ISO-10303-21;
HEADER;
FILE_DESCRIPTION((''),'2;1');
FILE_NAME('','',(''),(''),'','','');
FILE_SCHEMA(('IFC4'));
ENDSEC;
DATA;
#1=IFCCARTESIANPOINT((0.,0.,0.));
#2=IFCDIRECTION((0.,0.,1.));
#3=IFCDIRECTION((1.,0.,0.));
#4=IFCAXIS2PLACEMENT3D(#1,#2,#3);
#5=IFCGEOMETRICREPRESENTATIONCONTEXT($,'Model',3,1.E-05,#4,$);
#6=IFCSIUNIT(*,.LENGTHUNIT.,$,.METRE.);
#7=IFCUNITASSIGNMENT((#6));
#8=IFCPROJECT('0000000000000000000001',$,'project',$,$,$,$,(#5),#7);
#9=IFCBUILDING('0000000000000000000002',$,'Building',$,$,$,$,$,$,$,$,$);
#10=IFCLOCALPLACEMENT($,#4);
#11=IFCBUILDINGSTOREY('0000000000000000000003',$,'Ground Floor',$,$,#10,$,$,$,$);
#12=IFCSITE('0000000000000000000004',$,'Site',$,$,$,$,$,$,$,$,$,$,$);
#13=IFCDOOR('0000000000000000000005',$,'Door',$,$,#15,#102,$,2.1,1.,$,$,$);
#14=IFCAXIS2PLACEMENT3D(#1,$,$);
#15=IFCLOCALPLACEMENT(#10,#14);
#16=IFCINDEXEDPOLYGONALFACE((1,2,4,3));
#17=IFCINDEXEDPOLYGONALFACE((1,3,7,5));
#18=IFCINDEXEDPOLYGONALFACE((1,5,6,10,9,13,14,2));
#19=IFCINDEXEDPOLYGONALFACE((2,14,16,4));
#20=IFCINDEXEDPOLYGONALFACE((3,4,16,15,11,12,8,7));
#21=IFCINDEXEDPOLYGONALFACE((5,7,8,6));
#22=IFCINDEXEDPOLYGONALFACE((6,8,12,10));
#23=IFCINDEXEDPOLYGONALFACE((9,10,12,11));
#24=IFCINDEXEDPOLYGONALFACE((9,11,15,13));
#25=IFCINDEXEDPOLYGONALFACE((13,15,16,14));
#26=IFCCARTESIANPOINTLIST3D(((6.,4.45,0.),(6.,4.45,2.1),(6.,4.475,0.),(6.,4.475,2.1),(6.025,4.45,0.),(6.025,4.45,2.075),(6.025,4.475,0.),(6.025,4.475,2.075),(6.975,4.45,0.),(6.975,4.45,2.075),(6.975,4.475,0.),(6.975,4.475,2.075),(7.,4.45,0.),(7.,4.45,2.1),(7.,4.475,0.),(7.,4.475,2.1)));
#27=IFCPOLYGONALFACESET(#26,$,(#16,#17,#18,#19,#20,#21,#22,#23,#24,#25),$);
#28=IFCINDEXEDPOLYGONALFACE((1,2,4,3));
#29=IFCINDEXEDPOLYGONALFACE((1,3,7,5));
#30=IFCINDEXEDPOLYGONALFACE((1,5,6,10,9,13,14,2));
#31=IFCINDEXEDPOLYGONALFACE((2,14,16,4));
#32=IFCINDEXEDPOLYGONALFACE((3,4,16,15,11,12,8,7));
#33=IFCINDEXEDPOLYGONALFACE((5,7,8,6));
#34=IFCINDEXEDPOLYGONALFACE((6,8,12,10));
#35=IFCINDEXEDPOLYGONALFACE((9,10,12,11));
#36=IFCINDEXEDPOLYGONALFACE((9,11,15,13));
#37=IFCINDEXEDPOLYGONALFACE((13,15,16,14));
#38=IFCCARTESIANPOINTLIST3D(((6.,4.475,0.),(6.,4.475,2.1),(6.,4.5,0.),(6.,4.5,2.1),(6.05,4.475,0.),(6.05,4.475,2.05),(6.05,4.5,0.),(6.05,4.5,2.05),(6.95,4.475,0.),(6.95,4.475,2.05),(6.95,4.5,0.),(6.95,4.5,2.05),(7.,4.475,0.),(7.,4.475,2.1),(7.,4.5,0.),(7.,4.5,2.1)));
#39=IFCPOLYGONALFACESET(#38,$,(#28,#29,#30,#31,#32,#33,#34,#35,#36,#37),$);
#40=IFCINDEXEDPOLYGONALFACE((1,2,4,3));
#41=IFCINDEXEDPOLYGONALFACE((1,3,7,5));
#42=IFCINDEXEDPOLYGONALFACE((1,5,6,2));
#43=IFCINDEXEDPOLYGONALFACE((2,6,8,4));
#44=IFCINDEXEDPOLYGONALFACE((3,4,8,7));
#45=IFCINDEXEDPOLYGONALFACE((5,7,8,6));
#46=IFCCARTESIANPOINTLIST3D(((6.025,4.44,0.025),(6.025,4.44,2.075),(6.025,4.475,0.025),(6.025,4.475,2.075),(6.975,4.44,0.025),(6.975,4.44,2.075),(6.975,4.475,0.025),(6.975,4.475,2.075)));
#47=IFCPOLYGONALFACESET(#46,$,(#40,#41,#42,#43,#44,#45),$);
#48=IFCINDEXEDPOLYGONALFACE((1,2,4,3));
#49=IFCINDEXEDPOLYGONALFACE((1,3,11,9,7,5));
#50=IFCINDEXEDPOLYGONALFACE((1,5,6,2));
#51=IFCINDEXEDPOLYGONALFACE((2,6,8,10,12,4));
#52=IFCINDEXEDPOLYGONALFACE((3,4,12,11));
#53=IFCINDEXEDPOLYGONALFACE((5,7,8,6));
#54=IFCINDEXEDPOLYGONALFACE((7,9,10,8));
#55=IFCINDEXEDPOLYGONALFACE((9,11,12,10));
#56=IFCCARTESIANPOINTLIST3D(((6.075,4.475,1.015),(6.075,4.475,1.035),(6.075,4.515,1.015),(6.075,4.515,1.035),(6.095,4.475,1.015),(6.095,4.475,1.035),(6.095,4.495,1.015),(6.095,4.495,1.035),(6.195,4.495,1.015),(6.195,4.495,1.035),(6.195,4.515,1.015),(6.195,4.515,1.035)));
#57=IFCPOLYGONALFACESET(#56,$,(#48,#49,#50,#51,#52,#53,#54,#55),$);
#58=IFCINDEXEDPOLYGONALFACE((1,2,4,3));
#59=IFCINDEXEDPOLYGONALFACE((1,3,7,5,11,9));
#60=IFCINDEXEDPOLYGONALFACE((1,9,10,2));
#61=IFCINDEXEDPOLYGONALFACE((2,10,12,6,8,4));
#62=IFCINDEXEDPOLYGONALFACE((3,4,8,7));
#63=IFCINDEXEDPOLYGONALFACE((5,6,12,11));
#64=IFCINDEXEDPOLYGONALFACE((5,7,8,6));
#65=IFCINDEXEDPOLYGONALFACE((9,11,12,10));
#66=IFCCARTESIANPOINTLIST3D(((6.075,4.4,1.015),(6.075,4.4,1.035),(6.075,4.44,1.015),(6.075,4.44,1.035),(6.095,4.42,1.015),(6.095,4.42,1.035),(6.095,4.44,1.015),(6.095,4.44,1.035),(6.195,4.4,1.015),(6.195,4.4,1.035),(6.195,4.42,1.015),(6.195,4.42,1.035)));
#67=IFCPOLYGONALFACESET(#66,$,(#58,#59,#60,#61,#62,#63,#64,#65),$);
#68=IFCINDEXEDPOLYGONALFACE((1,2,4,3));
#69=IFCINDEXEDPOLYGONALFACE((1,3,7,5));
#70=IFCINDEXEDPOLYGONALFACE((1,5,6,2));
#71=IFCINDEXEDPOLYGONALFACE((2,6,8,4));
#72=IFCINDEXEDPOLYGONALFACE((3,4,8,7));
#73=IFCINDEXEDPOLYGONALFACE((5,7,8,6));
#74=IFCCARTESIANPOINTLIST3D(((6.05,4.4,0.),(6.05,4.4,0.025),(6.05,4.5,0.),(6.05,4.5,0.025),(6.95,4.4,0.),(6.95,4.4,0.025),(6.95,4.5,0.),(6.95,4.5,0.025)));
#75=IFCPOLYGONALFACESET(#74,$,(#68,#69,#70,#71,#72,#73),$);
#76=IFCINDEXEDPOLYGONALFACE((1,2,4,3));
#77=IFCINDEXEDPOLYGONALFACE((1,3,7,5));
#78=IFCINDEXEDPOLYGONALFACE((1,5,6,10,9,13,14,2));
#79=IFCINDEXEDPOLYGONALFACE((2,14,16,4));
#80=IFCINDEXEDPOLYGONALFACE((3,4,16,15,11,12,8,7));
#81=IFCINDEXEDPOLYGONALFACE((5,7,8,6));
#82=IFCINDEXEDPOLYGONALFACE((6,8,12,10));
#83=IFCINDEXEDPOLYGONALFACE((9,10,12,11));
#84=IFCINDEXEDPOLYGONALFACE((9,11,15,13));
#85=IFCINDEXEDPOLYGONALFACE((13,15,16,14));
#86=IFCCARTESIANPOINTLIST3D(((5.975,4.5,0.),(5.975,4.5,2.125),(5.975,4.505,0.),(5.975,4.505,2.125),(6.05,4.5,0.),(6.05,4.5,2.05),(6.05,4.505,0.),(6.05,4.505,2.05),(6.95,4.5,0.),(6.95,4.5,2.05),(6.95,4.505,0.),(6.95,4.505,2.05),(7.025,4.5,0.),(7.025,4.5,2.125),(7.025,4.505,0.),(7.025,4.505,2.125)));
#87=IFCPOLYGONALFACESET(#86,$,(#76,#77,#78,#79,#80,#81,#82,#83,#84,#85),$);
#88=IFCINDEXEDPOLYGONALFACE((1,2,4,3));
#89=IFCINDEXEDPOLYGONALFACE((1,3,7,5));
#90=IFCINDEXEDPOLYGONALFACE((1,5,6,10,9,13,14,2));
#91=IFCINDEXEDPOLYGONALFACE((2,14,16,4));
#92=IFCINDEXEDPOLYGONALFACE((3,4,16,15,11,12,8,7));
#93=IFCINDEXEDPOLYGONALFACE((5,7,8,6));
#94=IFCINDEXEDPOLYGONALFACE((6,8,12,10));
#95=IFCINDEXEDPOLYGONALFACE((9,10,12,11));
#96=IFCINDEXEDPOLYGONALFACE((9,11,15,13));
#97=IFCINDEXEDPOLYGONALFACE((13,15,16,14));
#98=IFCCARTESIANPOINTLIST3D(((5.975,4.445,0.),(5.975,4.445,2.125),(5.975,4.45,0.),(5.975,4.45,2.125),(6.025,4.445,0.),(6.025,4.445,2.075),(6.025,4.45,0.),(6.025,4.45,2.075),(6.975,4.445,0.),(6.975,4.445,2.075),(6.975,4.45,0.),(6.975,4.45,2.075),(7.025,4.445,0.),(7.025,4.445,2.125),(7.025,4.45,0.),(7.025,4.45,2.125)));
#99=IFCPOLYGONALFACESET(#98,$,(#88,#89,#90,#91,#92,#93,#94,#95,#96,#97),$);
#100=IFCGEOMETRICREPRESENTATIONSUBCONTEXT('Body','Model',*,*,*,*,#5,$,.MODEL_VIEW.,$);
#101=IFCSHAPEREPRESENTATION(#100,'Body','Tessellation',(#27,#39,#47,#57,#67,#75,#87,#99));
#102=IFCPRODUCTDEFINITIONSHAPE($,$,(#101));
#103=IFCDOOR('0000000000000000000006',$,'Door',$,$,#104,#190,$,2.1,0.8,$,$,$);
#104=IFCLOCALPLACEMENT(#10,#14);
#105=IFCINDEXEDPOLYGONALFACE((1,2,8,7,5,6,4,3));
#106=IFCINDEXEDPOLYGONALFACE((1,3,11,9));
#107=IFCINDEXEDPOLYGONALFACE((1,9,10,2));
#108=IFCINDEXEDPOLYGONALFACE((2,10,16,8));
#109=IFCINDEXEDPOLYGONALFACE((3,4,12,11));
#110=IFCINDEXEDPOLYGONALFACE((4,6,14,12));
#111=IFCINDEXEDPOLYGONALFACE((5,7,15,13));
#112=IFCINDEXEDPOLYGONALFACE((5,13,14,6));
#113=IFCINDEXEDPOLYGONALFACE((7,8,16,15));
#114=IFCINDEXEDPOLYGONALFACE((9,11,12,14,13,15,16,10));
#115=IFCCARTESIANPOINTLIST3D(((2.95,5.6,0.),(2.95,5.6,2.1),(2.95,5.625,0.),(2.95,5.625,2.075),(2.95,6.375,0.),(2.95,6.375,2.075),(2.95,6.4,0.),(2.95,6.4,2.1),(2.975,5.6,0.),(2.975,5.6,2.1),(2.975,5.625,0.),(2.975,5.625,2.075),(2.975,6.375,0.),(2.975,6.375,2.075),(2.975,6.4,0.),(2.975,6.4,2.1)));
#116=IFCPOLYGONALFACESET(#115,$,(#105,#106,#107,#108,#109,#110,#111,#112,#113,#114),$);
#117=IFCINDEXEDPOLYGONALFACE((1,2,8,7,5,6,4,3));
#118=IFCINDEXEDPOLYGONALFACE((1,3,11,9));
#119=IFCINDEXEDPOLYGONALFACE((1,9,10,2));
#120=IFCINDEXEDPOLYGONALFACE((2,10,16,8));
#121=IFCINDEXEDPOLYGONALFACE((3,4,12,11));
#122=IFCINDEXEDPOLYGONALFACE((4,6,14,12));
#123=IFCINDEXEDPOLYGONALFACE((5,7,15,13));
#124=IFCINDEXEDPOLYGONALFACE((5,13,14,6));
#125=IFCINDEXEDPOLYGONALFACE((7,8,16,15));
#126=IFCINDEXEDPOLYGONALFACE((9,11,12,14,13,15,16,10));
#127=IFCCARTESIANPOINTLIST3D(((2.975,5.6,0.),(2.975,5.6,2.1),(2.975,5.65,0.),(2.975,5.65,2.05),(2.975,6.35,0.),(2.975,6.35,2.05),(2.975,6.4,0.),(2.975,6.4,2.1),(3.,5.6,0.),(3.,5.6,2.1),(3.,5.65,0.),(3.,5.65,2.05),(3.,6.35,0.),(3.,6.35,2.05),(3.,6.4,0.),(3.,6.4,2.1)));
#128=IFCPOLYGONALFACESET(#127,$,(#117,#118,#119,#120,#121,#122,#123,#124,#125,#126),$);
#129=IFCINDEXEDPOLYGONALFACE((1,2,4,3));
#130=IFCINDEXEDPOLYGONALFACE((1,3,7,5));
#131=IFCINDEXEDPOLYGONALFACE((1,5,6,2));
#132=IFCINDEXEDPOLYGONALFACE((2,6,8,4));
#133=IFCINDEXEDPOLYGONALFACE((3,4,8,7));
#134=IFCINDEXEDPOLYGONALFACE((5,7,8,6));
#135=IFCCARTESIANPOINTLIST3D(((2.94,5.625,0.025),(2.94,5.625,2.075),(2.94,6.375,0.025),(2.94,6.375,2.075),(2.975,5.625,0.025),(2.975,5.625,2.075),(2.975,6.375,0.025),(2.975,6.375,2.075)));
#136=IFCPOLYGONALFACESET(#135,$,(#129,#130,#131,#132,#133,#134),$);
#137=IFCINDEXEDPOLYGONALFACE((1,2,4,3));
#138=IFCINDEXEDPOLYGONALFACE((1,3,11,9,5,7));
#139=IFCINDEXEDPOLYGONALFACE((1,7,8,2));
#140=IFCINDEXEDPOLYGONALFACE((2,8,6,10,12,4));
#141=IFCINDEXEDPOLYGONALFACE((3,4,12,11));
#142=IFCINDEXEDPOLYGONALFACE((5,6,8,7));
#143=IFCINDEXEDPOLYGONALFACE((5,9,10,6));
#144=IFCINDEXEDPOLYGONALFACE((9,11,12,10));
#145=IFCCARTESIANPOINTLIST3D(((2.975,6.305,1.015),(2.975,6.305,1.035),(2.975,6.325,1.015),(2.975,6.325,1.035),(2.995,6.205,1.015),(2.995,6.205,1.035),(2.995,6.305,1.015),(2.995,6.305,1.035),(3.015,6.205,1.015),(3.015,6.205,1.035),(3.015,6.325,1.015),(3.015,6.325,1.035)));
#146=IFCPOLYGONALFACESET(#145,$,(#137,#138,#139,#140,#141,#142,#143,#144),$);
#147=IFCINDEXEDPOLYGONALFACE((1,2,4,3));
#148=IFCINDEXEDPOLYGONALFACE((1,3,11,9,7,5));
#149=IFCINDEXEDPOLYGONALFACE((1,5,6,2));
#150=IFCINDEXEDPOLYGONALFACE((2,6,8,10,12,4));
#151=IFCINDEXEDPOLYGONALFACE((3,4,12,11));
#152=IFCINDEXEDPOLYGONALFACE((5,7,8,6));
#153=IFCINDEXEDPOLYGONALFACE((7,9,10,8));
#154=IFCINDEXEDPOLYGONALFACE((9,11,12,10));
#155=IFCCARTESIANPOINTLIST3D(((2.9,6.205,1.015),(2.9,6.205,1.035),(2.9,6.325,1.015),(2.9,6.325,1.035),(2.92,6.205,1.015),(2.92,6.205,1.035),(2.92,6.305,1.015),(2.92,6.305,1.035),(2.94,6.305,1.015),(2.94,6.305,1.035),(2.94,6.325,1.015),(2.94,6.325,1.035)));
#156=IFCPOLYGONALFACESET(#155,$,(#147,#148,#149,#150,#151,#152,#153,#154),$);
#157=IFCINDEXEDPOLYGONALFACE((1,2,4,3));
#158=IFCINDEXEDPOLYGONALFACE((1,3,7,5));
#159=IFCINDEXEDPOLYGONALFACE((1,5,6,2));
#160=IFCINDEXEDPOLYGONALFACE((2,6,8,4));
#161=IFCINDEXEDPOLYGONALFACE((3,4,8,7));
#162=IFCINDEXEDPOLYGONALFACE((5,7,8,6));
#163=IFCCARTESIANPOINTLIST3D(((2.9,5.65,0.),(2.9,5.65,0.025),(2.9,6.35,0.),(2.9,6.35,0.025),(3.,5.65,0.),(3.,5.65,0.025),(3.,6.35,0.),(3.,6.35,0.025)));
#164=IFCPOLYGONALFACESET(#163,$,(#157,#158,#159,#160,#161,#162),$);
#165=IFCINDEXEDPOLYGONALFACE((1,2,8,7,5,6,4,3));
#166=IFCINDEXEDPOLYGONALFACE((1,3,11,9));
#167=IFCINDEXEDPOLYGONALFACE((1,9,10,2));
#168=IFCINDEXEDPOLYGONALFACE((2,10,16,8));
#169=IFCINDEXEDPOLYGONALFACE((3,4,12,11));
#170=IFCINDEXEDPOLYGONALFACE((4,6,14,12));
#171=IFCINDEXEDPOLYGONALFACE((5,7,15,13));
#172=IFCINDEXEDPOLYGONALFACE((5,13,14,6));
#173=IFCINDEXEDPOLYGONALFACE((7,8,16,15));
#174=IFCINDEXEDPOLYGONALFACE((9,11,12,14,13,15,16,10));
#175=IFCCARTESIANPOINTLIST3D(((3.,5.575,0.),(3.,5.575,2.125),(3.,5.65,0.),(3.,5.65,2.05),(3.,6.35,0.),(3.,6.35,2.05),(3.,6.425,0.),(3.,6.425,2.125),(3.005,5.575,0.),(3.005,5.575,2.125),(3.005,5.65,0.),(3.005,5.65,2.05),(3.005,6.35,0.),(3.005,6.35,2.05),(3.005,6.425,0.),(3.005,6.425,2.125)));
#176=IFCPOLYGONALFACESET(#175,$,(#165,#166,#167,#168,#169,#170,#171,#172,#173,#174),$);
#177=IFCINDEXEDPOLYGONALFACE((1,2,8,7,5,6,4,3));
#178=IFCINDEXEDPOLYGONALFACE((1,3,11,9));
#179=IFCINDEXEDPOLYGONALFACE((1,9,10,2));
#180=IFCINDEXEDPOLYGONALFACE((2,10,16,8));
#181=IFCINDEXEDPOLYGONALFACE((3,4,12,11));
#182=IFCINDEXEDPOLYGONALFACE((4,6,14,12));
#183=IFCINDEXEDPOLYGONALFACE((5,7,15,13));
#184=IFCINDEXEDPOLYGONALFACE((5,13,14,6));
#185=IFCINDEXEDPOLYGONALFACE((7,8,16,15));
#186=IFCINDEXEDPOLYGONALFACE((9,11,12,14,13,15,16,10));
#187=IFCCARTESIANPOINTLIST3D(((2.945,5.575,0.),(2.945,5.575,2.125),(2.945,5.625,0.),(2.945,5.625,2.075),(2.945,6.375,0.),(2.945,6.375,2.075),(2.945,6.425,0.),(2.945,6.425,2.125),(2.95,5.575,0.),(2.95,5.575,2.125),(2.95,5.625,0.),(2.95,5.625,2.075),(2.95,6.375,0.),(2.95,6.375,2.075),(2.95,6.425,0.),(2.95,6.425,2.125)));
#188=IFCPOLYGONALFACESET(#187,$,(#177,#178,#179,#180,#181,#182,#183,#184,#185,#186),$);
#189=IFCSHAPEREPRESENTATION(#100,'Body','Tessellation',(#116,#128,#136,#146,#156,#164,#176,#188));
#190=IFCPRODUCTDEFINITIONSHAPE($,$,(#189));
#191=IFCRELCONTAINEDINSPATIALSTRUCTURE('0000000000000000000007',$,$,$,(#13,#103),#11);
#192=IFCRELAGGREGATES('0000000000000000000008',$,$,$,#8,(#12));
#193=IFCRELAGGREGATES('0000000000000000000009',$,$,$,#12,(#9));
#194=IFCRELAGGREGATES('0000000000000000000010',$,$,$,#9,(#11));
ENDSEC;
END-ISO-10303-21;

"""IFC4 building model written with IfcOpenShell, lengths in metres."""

from ifc_helpers import new_model, si_unit, frame, origin_with_axes, place, context, subcontext, project, spatial, line, indexed_curve, outline, extrude, element, save


model = new_model("IFC4")

# Units and contexts
model_context = context("Model", 3, precision=1e-05, world=origin_with_axes())
body_context = subcontext(model_context, "Body", "Model", "MODEL_VIEW")
ifc_project = project(units=[si_unit("LENGTHUNIT", "METRE")], contexts=[model_context])

# Site, building, storey
site = spatial("IfcSite", under=ifc_project, Name="Site")
building = spatial("IfcBuilding", under=site, Name="Building")
storey_placement = place(None, origin_with_axes())
storey = spatial("IfcBuildingStorey", under=building, at=storey_placement, Name="Ground Floor")

# Doors
door_1_placement = place(storey_placement, frame((7.0, 4.5, 0.0), z_axis=(0.0, 0.0, 1.0), x_axis=(-1.0, 0.0, 0.0)))
element("IfcDoor", 1, at=door_1_placement, inside=storey, Name="Door", OverallHeight=2.1, OverallWidth=1.0, context=body_context, shape_type="SweptSolid", body=[
    extrude(outline(indexed_curve([(0.0, 0.0), (0.0, 2.1), (1.0, 2.1), (1.0, 0.0), (0.975, 0.0), (0.975, 2.075), (0.025, 2.075), (0.025, 0.0)], segments=[line(1, 2, 3, 4, 5, 6, 7, 8, 1)])), frame((0.0, 0.025, 0.0), z_axis=(0.0, -1.0, 0.0), x_axis=(1.0, 0.0, 0.0)), (0.0, 0.0, -1.0), 0.025),
    extrude(outline(indexed_curve([(0.0, 0.0), (0.0, 2.1), (1.0, 2.1), (1.0, 0.0), (0.95, 0.0), (0.95, 2.05), (0.05, 2.05), (0.05, 0.0)], segments=[line(1, 2, 3, 4, 5, 6, 7, 8, 1)])), frame((0.0, 0.0, 0.0), z_axis=(0.0, -1.0, 0.0), x_axis=(1.0, 0.0, 0.0)), (0.0, 0.0, -1.0), 0.025),
    extrude(outline(indexed_curve([(0.0, 0.0), (0.95, 0.0), (0.95, 0.035), (0.0, 0.035)], segments=[line(1, 2, 3, 4, 1)])), frame((0.025, 0.025, 0.025), z_axis=(0.0, 0.0, 1.0), x_axis=(1.0, 0.0, 0.0)), (0.0, 0.0, 1.0), 2.05),
    extrude(outline(indexed_curve([(0.0, 0.0), (0.0, -0.04), (-0.12, -0.04), (-0.12, -0.02), (-0.02, -0.02), (-0.02, 0.0)], segments=[line(1, 2, 3, 4, 5, 6, 1)])), frame((0.925, 0.025, 1.015), z_axis=(0.0, 0.0, 1.0), x_axis=(1.0, 0.0, 0.0)), (0.0, 0.0, 1.0), 0.02),
    extrude(outline(indexed_curve([(0.0, 0.0), (0.0, 0.04), (-0.12, 0.04), (-0.12, 0.02), (-0.02, 0.02), (-0.02, 0.0)], segments=[line(1, 2, 3, 4, 5, 6, 1)])), frame((0.925, 0.06, 1.015), z_axis=(0.0, 0.0, 1.0), x_axis=(1.0, 0.0, 0.0)), (0.0, 0.0, 1.0), 0.02),
    extrude(outline(indexed_curve([(0.0, 0.0), (0.9, 0.0), (0.9, 0.1), (0.0, 0.1)], segments=[line(1, 2, 3, 4, 1)])), frame((0.05, 0.0, 0.0), z_axis=(0.0, 0.0, 1.0), x_axis=(1.0, 0.0, 0.0)), (0.0, 0.0, 1.0), 0.025),
    extrude(outline(indexed_curve([(0.0, 0.0), (0.0, 2.125), (1.05, 2.125), (1.05, 0.0), (0.975, 0.0), (0.975, 2.05), (0.075, 2.05), (0.075, 0.0)], segments=[line(1, 2, 3, 4, 5, 6, 7, 8, 1)])), frame((-0.025, -0.005, 0.0), z_axis=(0.0, -1.0, 0.0), x_axis=(1.0, 0.0, 0.0)), (0.0, 0.0, -1.0), 0.005),
    extrude(outline(indexed_curve([(0.0, 0.0), (0.0, 2.125), (1.05, 2.125), (1.05, 0.0), (1.0, 0.0), (1.0, 2.075), (0.05, 2.075), (0.05, 0.0)], segments=[line(1, 2, 3, 4, 5, 6, 7, 8, 1)])), frame((-0.025, 0.05, 0.0), z_axis=(0.0, -1.0, 0.0), x_axis=(1.0, 0.0, 0.0)), (0.0, 0.0, -1.0), 0.005),
])
door_2_placement = place(storey_placement, frame((3.0, 5.6, 0.0), z_axis=(0.0, 0.0, 1.0), x_axis=(0.0, 1.0, 0.0)))
element("IfcDoor", 2, at=door_2_placement, inside=storey, Name="Door", OverallHeight=2.1, OverallWidth=0.8, context=body_context, shape_type="SweptSolid", body=[
    extrude(outline(indexed_curve([(0.0, 0.0), (0.0, 2.1), (0.8, 2.1), (0.8, 0.0), (0.775, 0.0), (0.775, 2.075), (0.025, 2.075), (0.025, 0.0)], segments=[line(1, 2, 3, 4, 5, 6, 7, 8, 1)])), frame((0.0, 0.025, 0.0), z_axis=(0.0, -1.0, 0.0), x_axis=(1.0, 0.0, 0.0)), (0.0, 0.0, -1.0), 0.025),
    extrude(outline(indexed_curve([(0.0, 0.0), (0.0, 2.1), (0.8, 2.1), (0.8, 0.0), (0.75, 0.0), (0.75, 2.05), (0.05, 2.05), (0.05, 0.0)], segments=[line(1, 2, 3, 4, 5, 6, 7, 8, 1)])), frame((0.0, 0.0, 0.0), z_axis=(0.0, -1.0, 0.0), x_axis=(1.0, 0.0, 0.0)), (0.0, 0.0, -1.0), 0.025),
    extrude(outline(indexed_curve([(0.0, 0.0), (0.75, 0.0), (0.75, 0.035), (0.0, 0.035)], segments=[line(1, 2, 3, 4, 1)])), frame((0.025, 0.025, 0.025), z_axis=(0.0, 0.0, 1.0), x_axis=(1.0, 0.0, 0.0)), (0.0, 0.0, 1.0), 2.05),
    extrude(outline(indexed_curve([(0.0, 0.0), (0.0, -0.04), (-0.12, -0.04), (-0.12, -0.02), (-0.02, -0.02), (-0.02, 0.0)], segments=[line(1, 2, 3, 4, 5, 6, 1)])), frame((0.725, 0.025, 1.015), z_axis=(0.0, 0.0, 1.0), x_axis=(1.0, 0.0, 0.0)), (0.0, 0.0, 1.0), 0.02),
    extrude(outline(indexed_curve([(0.0, 0.0), (0.0, 0.04), (-0.12, 0.04), (-0.12, 0.02), (-0.02, 0.02), (-0.02, 0.0)], segments=[line(1, 2, 3, 4, 5, 6, 1)])), frame((0.725, 0.06, 1.015), z_axis=(0.0, 0.0, 1.0), x_axis=(1.0, 0.0, 0.0)), (0.0, 0.0, 1.0), 0.02),
    extrude(outline(indexed_curve([(0.0, 0.0), (0.7, 0.0), (0.7, 0.1), (0.0, 0.1)], segments=[line(1, 2, 3, 4, 1)])), frame((0.05, 0.0, 0.0), z_axis=(0.0, 0.0, 1.0), x_axis=(1.0, 0.0, 0.0)), (0.0, 0.0, 1.0), 0.025),
    extrude(outline(indexed_curve([(0.0, 0.0), (0.0, 2.125), (0.85, 2.125), (0.85, 0.0), (0.775, 0.0), (0.775, 2.05), (0.075, 2.05), (0.075, 0.0)], segments=[line(1, 2, 3, 4, 5, 6, 7, 8, 1)])), frame((-0.025, -0.005, 0.0), z_axis=(0.0, -1.0, 0.0), x_axis=(1.0, 0.0, 0.0)), (0.0, 0.0, -1.0), 0.005),
    extrude(outline(indexed_curve([(0.0, 0.0), (0.0, 2.125), (0.85, 2.125), (0.85, 0.0), (0.8, 0.0), (0.8, 2.075), (0.05, 2.075), (0.05, 0.0)], segments=[line(1, 2, 3, 4, 5, 6, 7, 8, 1)])), frame((-0.025, 0.05, 0.0), z_axis=(0.0, -1.0, 0.0), x_axis=(1.0, 0.0, 0.0)), (0.0, 0.0, -1.0), 0.005),
])

save(model, "model.ifc")
